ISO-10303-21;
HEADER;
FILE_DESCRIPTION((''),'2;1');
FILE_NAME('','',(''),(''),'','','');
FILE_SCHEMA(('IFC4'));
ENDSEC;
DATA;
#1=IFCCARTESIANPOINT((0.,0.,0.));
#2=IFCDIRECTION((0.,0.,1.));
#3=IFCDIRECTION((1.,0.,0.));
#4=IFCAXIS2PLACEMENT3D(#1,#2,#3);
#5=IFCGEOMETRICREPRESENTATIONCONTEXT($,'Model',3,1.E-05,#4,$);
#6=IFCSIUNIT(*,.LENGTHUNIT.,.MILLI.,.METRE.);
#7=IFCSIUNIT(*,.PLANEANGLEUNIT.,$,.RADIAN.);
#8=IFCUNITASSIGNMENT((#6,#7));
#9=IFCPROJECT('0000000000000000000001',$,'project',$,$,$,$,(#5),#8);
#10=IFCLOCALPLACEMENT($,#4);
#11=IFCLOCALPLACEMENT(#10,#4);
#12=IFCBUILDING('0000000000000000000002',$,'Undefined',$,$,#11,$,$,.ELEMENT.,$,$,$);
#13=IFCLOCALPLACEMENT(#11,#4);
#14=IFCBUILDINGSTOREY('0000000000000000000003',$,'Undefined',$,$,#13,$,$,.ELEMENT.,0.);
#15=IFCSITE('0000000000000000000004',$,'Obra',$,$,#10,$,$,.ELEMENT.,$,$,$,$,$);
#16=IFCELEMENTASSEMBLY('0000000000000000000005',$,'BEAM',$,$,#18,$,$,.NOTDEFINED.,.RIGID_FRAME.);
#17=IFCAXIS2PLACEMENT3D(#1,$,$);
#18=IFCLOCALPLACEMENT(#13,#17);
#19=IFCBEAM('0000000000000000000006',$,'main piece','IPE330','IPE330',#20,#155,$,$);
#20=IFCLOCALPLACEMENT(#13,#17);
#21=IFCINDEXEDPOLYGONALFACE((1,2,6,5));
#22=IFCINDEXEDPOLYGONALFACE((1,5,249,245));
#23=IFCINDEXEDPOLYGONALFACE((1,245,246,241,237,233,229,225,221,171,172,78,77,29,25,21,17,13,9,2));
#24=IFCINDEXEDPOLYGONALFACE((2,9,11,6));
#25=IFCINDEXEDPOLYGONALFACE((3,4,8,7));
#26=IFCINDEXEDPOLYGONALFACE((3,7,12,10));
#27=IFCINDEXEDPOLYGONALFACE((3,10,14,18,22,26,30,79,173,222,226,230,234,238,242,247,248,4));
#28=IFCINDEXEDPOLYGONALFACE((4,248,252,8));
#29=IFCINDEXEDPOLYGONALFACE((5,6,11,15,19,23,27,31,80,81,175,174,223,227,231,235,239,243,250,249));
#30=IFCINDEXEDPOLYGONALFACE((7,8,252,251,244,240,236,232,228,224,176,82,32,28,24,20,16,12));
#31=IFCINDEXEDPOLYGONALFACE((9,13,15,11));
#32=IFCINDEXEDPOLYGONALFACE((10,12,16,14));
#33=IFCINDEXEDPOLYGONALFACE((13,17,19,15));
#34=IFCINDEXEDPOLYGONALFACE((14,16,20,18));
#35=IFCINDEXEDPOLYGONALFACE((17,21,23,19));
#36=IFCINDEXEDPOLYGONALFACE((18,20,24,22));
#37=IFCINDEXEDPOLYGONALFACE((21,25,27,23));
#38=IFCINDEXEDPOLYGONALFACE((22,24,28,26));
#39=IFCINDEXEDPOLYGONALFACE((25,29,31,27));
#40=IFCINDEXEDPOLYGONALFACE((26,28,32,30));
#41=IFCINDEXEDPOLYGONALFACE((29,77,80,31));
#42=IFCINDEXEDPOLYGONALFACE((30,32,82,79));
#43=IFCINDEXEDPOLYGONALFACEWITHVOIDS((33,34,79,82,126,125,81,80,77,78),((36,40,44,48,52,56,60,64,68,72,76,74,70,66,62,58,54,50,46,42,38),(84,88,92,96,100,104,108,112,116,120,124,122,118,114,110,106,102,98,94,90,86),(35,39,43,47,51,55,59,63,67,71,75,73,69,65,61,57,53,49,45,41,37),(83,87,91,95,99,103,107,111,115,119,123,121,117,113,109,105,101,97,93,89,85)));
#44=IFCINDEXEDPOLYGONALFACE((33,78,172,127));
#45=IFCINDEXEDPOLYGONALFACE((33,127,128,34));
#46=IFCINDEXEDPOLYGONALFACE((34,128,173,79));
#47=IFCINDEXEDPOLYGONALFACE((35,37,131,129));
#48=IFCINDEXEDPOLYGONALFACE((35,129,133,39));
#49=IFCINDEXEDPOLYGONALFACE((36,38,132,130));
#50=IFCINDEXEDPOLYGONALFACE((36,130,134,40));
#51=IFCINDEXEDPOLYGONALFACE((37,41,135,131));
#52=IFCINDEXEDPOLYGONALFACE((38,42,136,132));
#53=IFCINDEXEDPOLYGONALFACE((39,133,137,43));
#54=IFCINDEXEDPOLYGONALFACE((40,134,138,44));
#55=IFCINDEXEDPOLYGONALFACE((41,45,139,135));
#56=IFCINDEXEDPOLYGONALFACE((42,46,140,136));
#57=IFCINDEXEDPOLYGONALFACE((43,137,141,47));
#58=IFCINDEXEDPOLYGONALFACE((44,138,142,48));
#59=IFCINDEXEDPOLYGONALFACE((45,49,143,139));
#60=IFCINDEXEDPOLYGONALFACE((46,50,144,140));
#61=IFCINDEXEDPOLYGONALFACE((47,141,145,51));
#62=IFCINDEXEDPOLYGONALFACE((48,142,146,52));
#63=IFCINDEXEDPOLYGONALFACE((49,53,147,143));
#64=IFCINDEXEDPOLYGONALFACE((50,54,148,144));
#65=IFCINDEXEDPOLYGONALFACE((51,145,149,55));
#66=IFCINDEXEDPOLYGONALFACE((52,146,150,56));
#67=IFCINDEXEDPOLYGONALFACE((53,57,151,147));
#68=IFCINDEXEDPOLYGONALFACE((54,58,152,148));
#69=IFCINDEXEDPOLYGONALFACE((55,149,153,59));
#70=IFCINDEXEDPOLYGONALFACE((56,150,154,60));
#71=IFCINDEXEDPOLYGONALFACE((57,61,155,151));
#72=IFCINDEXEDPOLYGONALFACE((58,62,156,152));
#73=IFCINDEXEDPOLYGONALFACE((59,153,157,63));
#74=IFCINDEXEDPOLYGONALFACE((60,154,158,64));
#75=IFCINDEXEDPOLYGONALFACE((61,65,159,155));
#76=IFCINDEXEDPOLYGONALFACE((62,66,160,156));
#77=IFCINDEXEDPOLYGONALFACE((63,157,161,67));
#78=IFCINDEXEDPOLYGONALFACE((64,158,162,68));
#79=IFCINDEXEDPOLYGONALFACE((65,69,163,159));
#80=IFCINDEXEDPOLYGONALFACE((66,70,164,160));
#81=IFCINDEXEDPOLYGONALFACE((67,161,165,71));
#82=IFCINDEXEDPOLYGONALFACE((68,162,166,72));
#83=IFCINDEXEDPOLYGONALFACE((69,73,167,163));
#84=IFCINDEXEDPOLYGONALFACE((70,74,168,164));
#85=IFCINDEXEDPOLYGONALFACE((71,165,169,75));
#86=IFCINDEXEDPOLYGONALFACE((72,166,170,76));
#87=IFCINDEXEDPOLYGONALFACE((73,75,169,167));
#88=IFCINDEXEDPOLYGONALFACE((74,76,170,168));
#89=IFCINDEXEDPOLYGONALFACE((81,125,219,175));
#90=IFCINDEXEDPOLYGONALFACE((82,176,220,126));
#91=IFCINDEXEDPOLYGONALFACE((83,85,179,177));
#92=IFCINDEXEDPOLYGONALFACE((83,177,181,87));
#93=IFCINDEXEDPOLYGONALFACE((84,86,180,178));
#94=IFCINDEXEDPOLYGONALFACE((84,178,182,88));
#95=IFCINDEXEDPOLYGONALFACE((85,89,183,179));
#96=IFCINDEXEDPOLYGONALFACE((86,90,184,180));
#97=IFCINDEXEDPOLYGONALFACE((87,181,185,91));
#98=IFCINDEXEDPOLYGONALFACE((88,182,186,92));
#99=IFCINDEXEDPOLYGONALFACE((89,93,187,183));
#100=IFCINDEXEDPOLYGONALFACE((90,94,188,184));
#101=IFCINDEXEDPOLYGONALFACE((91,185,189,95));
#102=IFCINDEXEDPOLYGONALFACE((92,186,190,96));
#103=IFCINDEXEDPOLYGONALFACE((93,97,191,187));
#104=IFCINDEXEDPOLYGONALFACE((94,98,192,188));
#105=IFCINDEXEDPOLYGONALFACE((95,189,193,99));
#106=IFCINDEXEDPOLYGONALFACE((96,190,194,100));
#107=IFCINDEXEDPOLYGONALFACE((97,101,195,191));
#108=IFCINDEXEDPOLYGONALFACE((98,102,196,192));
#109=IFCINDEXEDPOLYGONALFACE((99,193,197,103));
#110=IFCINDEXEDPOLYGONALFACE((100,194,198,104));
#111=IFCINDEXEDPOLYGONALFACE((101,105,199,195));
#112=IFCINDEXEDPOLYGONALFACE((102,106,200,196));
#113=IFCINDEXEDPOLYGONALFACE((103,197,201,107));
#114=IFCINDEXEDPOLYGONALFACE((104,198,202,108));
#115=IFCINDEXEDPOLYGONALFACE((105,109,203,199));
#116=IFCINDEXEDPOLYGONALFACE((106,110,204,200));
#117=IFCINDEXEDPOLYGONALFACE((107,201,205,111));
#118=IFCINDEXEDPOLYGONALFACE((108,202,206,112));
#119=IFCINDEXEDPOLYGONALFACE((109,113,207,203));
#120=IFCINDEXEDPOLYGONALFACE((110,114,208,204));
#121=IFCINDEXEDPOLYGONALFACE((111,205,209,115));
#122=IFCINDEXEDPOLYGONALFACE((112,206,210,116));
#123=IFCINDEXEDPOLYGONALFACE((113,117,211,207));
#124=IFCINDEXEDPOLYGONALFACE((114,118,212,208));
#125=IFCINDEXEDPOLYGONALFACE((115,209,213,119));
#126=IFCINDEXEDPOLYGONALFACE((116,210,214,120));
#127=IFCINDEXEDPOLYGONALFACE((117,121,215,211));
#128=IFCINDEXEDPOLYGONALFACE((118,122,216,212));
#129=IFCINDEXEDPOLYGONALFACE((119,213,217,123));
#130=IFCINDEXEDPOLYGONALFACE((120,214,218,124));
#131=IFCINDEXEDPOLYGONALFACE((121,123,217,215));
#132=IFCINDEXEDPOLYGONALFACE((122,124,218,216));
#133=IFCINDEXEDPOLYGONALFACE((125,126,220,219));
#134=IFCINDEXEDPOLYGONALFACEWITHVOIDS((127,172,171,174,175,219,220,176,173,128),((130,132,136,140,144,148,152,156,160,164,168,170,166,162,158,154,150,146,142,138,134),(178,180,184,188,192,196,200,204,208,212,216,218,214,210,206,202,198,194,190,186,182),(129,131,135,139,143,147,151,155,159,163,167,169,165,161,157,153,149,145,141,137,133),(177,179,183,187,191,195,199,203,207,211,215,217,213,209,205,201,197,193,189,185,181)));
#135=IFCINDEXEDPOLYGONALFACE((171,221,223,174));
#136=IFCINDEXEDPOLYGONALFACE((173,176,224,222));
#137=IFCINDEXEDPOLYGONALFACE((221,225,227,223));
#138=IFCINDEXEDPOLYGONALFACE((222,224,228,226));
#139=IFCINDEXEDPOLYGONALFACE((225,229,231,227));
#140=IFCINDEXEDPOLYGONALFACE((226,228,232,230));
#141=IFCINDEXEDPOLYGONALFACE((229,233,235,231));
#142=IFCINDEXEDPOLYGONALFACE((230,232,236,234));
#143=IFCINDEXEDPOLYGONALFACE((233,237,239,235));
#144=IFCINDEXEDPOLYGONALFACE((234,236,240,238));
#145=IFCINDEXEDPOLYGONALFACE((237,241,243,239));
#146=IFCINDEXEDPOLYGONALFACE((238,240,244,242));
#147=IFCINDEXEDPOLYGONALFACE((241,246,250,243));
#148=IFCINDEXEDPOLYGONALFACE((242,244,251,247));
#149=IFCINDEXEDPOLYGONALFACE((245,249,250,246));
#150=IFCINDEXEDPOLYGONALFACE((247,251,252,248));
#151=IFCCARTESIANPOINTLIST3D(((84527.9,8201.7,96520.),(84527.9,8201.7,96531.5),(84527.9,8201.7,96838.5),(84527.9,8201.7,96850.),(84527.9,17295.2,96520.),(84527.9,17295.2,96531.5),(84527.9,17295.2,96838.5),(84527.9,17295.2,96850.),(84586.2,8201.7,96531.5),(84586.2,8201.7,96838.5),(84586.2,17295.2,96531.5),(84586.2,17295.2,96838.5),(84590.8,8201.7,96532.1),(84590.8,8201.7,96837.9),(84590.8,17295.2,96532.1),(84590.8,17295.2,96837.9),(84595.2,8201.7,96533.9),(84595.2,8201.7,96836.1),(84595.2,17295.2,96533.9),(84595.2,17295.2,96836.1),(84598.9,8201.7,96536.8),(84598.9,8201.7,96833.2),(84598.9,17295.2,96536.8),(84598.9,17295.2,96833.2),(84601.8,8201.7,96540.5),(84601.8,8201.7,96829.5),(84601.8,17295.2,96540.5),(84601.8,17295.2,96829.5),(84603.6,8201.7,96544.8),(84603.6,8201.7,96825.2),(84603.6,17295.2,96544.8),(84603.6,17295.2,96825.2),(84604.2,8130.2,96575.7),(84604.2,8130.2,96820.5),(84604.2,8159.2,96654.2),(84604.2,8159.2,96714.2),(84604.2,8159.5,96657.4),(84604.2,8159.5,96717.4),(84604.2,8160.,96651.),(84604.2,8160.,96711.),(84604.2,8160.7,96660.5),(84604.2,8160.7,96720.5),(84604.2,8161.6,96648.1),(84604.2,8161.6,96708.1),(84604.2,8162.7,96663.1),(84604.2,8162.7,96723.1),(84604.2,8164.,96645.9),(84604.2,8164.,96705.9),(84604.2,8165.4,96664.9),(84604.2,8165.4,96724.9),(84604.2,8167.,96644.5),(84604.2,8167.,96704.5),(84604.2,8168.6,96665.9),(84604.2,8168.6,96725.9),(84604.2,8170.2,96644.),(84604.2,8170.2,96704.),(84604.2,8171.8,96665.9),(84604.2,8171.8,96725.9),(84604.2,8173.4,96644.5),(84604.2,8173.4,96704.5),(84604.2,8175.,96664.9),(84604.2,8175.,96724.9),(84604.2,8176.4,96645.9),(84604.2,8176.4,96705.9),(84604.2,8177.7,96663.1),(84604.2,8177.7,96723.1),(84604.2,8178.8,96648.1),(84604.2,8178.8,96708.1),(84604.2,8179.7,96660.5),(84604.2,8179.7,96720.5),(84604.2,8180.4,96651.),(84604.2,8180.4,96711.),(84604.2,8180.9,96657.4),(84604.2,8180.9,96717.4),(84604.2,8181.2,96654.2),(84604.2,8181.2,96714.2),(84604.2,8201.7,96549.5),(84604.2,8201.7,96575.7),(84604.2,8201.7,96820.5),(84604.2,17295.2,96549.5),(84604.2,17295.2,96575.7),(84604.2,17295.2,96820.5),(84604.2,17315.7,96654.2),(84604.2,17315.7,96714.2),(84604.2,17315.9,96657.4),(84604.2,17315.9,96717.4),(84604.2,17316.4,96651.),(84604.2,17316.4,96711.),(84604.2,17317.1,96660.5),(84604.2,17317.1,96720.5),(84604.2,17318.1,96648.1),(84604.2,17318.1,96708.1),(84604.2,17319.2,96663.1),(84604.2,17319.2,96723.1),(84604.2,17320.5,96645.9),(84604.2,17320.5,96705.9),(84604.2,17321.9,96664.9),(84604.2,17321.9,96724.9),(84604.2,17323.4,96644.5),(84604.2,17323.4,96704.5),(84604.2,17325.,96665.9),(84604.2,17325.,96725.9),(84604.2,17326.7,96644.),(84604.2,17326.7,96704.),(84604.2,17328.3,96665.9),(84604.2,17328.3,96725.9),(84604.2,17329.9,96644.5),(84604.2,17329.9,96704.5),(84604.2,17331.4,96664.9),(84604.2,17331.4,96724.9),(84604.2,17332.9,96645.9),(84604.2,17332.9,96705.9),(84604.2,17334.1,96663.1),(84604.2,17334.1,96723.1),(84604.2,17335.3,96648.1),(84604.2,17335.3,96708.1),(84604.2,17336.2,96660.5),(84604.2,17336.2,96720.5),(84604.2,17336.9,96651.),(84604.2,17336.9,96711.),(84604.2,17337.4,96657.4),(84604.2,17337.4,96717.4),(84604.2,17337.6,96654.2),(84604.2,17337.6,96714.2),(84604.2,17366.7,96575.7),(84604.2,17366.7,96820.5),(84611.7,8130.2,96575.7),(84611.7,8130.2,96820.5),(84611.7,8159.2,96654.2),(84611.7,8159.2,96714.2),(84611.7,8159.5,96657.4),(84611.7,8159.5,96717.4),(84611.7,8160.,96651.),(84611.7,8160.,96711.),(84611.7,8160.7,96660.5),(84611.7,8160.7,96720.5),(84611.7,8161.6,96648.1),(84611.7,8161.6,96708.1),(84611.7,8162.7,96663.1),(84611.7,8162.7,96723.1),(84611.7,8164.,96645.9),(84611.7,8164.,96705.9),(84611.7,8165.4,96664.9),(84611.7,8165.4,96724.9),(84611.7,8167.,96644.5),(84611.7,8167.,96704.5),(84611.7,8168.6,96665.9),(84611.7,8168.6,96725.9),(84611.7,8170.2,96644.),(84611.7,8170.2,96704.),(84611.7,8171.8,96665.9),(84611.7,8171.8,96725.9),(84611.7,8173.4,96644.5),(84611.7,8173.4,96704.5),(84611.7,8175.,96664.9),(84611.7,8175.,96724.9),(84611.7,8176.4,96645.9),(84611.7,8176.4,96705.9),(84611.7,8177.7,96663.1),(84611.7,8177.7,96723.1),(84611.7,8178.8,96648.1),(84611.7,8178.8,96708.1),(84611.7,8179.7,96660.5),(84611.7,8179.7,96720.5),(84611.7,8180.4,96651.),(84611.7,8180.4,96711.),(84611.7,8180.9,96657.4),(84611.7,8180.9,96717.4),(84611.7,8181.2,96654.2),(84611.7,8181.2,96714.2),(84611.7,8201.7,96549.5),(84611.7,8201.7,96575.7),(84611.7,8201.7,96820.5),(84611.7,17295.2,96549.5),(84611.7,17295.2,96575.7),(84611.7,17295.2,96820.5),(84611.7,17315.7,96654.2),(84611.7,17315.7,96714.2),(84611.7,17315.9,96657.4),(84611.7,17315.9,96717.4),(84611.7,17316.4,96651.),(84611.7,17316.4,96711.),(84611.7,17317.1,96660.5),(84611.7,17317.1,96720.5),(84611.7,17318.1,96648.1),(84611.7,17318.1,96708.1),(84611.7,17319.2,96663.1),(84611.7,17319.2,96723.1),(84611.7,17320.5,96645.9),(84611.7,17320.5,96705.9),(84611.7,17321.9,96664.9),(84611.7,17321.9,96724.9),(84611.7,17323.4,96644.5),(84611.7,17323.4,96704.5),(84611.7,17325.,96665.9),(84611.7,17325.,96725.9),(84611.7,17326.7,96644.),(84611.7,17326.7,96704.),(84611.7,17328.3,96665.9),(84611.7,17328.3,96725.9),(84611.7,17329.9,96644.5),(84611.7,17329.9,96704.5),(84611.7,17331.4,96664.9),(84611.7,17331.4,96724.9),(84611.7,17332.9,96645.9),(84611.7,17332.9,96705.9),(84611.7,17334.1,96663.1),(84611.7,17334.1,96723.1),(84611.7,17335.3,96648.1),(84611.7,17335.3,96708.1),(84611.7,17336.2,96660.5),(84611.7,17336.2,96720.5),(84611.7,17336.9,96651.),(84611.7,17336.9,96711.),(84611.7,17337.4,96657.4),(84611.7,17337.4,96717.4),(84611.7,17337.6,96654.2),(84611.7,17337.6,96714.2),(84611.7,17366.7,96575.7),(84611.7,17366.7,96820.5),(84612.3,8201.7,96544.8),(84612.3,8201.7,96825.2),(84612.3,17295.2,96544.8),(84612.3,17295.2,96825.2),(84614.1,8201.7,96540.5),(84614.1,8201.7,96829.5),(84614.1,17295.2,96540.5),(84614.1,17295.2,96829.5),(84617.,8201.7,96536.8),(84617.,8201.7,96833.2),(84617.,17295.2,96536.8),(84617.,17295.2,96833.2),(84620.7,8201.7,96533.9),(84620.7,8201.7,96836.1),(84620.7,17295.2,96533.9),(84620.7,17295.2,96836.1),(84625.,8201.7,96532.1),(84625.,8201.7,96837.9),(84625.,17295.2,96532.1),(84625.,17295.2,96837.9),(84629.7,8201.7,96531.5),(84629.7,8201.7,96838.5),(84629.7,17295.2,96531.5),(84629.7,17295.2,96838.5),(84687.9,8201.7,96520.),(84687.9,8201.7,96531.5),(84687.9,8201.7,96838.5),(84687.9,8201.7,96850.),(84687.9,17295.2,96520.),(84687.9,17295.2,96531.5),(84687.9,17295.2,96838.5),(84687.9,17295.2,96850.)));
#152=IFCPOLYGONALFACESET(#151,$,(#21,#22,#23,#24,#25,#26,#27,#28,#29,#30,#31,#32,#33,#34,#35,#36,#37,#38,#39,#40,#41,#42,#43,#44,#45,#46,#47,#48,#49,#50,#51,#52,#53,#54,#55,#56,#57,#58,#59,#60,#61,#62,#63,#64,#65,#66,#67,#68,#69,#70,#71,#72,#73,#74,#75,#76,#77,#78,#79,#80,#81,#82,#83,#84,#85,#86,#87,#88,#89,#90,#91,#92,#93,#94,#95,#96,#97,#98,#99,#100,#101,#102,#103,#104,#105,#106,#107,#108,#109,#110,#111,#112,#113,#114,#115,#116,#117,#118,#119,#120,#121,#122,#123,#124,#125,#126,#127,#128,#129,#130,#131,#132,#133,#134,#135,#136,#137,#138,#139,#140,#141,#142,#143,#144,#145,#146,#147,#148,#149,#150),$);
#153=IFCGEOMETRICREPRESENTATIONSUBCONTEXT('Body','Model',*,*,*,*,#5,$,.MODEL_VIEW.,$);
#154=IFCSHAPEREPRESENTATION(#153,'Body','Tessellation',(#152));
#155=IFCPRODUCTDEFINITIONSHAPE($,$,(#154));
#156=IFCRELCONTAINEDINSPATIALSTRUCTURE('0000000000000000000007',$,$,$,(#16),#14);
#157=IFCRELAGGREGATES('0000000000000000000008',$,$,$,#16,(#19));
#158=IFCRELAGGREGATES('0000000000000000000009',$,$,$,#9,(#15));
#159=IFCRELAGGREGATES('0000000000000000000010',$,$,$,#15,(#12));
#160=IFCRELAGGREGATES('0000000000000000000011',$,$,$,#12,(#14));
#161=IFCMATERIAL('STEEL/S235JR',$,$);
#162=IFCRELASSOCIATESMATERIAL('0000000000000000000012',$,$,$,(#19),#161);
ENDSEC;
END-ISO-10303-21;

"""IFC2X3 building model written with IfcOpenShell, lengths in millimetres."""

from ifc_helpers import new_model, si_unit, frame, origin_with_axes, origin_2d_with_axis, place, context, subcontext, project, spatial, rectangle, circle, i_section, extrude, clip, halfspace, source, transform, mapped, material, element, aggregate, save


model = new_model("IFC2X3")

# Units and contexts
model_context = context("Model", 3, precision=1e-05, world=origin_with_axes())
body_context = subcontext(model_context, "Body", "Model", "MODEL_VIEW")
ifc_project = project(units=[si_unit("LENGTHUNIT", "METRE", prefix="MILLI"), si_unit("PLANEANGLEUNIT", "RADIAN")], contexts=[model_context])

# Site, building, storey
site_placement = place(None, origin_with_axes())
site = spatial("IfcSite", under=ifc_project, at=site_placement, Name="Obra", CompositionType="ELEMENT")
building_placement = place(site_placement, origin_with_axes())
building = spatial("IfcBuilding", under=site, at=building_placement, Name="Undefined", CompositionType="ELEMENT")
storey_placement = place(building_placement, origin_with_axes())
storey = spatial("IfcBuildingStorey", under=building, at=storey_placement, Name="Undefined", CompositionType="ELEMENT", Elevation=0.0)

# Element assembly, beam, openings
ifc_material = material(Name="STEEL/S235JR")
shared_shape_1 = source(origin_with_axes(), body_context, "Body", "SweptSolid", [
    extrude(circle(Radius=11.0, at=origin_2d_with_axis()), frame((0.0, -3.9, 0.0), z_axis=(0.0, 1.0, 0.0), x_axis=(1.0, 0.0, 0.0)), (0.0, 0.0, 1.0), 7.7),
])
assembly_1_placement = place(storey_placement, origin_with_axes())
assembly_1 = element("IfcElementAssembly", 1, at=assembly_1_placement, inside=storey, Name="BEAM", AssemblyPlace="NOTDEFINED", PredefinedType="RIGID_FRAME")
beam_1_placement = place(assembly_1_placement, frame((84607.9, 8215.2, 96685.0), z_axis=(0.0, 0.0, 1.0), x_axis=(0.0, 1.0, 0.0)))
beam_1 = element("IfcBeam", 2, at=beam_1_placement, material=ifc_material, Name="main piece", Description="IPE330", ObjectType="IPE330", context=body_context, shape_type="Clipping", body=[
    clip(clip(extrude(i_section(OverallWidth=160.0, OverallDepth=330.0, WebThickness=7.5, FlangeThickness=11.5, FilletRadius=18.0, at=origin_2d_with_axis()), frame((9151.5, 0.0, 0.0), z_axis=(-1.0, 0.0, 0.0), x_axis=(0.0, -1.0, 0.0)), (0.0, 0.0, 1.0), 9236.5), halfspace(frame((9151.5, 0.0, -265.0), z_axis=(-1.0, 0.0, 0.0), x_axis=(0.0, 1.0, 0.0)), True)), halfspace(frame((-85.0, 0.0, -265.0), z_axis=(1.0, 0.0, 0.0), x_axis=(0.0, -1.0, 0.0)), True)),
])
opening_1_placement = place(assembly_1_placement, frame((84607.9, 8215.2, 96685.0), z_axis=(0.0, 0.0, 1.0), x_axis=(0.0, 1.0, 0.0)))
element("IfcOpeningElement", 3, at=opening_1_placement, cuts=beam_1, ObjectType="Recess", context=body_context, shape_type="SweptSolid", body=[
    extrude(rectangle(XDim=56.7, YDim=83.5, at=origin_2d_with_axis()), frame((9121.7, 81.0, -137.7), z_axis=(0.0, -1.0, 0.0), x_axis=(0.0, 0.0, -1.0)), (0.0, 0.0, 1.0), 162.0),
])
opening_2_placement = place(assembly_1_placement, frame((84607.9, 8215.2, 96685.0), z_axis=(0.0, 0.0, 1.0), x_axis=(0.0, 1.0, 0.0)))
element("IfcOpeningElement", 4, at=opening_2_placement, cuts=beam_1, ObjectType="Recess", context=body_context, shape_type="SweptSolid", body=[
    extrude(rectangle(XDim=30.5, YDim=83.5, at=origin_2d_with_axis()), frame((9121.7, 81.0, 150.7), z_axis=(0.0, -1.0, 0.0), x_axis=(0.0, 0.0, -1.0)), (0.0, 0.0, 1.0), 162.0),
])
opening_3_placement = place(assembly_1_placement, frame((84607.9, 8215.2, 96685.0), z_axis=(0.0, 0.0, 1.0), x_axis=(0.0, 1.0, 0.0)))
element("IfcOpeningElement", 5, at=opening_3_placement, cuts=beam_1, ObjectType="Recess", context=body_context, shape_type="SweptSolid", body=[
    extrude(rectangle(XDim=56.7, YDim=83.5, at=origin_2d_with_axis()), frame((-55.3, -81.0, -137.7), z_axis=(0.0, 1.0, 0.0), x_axis=(0.0, 0.0, -1.0)), (0.0, 0.0, 1.0), 162.0),
])
opening_4_placement = place(assembly_1_placement, frame((84607.9, 8215.2, 96685.0), z_axis=(0.0, 0.0, 1.0), x_axis=(0.0, 1.0, 0.0)))
element("IfcOpeningElement", 6, at=opening_4_placement, cuts=beam_1, ObjectType="Recess", context=body_context, shape_type="SweptSolid", body=[
    extrude(rectangle(XDim=30.5, YDim=83.5, at=origin_2d_with_axis()), frame((-55.3, -81.0, 150.7), z_axis=(0.0, 1.0, 0.0), x_axis=(0.0, 0.0, -1.0)), (0.0, 0.0, 1.0), 162.0),
])
opening_5_placement = place(assembly_1_placement, frame((84607.9, 17366.7, 96850.0), z_axis=(0.0, -1.0, 0.0), x_axis=(0.0, 0.0, -1.0)))
element("IfcOpeningElement", 7, at=opening_5_placement, cuts=beam_1, ObjectType="Opening", context=body_context, shape_type="MappedRepresentation", body=[
    mapped(shared_shape_1, transform((135.0, 0.0, 40.0))),
    mapped(shared_shape_1, transform((195.0, 0.0, 40.0))),
])
opening_6_placement = place(assembly_1_placement, frame((84607.9, 8130.2, 96850.0), z_axis=(0.0, 1.0, 0.0), x_axis=(0.0, 0.0, -1.0)))
element("IfcOpeningElement", 8, at=opening_6_placement, cuts=beam_1, ObjectType="Opening", context=body_context, shape_type="MappedRepresentation", body=[
    mapped(shared_shape_1, transform((135.0, 0.0, 40.0))),
    mapped(shared_shape_1, transform((195.0, 0.0, 40.0))),
])
aggregate(assembly_1, [beam_1])

save(model, "model.ifc")
